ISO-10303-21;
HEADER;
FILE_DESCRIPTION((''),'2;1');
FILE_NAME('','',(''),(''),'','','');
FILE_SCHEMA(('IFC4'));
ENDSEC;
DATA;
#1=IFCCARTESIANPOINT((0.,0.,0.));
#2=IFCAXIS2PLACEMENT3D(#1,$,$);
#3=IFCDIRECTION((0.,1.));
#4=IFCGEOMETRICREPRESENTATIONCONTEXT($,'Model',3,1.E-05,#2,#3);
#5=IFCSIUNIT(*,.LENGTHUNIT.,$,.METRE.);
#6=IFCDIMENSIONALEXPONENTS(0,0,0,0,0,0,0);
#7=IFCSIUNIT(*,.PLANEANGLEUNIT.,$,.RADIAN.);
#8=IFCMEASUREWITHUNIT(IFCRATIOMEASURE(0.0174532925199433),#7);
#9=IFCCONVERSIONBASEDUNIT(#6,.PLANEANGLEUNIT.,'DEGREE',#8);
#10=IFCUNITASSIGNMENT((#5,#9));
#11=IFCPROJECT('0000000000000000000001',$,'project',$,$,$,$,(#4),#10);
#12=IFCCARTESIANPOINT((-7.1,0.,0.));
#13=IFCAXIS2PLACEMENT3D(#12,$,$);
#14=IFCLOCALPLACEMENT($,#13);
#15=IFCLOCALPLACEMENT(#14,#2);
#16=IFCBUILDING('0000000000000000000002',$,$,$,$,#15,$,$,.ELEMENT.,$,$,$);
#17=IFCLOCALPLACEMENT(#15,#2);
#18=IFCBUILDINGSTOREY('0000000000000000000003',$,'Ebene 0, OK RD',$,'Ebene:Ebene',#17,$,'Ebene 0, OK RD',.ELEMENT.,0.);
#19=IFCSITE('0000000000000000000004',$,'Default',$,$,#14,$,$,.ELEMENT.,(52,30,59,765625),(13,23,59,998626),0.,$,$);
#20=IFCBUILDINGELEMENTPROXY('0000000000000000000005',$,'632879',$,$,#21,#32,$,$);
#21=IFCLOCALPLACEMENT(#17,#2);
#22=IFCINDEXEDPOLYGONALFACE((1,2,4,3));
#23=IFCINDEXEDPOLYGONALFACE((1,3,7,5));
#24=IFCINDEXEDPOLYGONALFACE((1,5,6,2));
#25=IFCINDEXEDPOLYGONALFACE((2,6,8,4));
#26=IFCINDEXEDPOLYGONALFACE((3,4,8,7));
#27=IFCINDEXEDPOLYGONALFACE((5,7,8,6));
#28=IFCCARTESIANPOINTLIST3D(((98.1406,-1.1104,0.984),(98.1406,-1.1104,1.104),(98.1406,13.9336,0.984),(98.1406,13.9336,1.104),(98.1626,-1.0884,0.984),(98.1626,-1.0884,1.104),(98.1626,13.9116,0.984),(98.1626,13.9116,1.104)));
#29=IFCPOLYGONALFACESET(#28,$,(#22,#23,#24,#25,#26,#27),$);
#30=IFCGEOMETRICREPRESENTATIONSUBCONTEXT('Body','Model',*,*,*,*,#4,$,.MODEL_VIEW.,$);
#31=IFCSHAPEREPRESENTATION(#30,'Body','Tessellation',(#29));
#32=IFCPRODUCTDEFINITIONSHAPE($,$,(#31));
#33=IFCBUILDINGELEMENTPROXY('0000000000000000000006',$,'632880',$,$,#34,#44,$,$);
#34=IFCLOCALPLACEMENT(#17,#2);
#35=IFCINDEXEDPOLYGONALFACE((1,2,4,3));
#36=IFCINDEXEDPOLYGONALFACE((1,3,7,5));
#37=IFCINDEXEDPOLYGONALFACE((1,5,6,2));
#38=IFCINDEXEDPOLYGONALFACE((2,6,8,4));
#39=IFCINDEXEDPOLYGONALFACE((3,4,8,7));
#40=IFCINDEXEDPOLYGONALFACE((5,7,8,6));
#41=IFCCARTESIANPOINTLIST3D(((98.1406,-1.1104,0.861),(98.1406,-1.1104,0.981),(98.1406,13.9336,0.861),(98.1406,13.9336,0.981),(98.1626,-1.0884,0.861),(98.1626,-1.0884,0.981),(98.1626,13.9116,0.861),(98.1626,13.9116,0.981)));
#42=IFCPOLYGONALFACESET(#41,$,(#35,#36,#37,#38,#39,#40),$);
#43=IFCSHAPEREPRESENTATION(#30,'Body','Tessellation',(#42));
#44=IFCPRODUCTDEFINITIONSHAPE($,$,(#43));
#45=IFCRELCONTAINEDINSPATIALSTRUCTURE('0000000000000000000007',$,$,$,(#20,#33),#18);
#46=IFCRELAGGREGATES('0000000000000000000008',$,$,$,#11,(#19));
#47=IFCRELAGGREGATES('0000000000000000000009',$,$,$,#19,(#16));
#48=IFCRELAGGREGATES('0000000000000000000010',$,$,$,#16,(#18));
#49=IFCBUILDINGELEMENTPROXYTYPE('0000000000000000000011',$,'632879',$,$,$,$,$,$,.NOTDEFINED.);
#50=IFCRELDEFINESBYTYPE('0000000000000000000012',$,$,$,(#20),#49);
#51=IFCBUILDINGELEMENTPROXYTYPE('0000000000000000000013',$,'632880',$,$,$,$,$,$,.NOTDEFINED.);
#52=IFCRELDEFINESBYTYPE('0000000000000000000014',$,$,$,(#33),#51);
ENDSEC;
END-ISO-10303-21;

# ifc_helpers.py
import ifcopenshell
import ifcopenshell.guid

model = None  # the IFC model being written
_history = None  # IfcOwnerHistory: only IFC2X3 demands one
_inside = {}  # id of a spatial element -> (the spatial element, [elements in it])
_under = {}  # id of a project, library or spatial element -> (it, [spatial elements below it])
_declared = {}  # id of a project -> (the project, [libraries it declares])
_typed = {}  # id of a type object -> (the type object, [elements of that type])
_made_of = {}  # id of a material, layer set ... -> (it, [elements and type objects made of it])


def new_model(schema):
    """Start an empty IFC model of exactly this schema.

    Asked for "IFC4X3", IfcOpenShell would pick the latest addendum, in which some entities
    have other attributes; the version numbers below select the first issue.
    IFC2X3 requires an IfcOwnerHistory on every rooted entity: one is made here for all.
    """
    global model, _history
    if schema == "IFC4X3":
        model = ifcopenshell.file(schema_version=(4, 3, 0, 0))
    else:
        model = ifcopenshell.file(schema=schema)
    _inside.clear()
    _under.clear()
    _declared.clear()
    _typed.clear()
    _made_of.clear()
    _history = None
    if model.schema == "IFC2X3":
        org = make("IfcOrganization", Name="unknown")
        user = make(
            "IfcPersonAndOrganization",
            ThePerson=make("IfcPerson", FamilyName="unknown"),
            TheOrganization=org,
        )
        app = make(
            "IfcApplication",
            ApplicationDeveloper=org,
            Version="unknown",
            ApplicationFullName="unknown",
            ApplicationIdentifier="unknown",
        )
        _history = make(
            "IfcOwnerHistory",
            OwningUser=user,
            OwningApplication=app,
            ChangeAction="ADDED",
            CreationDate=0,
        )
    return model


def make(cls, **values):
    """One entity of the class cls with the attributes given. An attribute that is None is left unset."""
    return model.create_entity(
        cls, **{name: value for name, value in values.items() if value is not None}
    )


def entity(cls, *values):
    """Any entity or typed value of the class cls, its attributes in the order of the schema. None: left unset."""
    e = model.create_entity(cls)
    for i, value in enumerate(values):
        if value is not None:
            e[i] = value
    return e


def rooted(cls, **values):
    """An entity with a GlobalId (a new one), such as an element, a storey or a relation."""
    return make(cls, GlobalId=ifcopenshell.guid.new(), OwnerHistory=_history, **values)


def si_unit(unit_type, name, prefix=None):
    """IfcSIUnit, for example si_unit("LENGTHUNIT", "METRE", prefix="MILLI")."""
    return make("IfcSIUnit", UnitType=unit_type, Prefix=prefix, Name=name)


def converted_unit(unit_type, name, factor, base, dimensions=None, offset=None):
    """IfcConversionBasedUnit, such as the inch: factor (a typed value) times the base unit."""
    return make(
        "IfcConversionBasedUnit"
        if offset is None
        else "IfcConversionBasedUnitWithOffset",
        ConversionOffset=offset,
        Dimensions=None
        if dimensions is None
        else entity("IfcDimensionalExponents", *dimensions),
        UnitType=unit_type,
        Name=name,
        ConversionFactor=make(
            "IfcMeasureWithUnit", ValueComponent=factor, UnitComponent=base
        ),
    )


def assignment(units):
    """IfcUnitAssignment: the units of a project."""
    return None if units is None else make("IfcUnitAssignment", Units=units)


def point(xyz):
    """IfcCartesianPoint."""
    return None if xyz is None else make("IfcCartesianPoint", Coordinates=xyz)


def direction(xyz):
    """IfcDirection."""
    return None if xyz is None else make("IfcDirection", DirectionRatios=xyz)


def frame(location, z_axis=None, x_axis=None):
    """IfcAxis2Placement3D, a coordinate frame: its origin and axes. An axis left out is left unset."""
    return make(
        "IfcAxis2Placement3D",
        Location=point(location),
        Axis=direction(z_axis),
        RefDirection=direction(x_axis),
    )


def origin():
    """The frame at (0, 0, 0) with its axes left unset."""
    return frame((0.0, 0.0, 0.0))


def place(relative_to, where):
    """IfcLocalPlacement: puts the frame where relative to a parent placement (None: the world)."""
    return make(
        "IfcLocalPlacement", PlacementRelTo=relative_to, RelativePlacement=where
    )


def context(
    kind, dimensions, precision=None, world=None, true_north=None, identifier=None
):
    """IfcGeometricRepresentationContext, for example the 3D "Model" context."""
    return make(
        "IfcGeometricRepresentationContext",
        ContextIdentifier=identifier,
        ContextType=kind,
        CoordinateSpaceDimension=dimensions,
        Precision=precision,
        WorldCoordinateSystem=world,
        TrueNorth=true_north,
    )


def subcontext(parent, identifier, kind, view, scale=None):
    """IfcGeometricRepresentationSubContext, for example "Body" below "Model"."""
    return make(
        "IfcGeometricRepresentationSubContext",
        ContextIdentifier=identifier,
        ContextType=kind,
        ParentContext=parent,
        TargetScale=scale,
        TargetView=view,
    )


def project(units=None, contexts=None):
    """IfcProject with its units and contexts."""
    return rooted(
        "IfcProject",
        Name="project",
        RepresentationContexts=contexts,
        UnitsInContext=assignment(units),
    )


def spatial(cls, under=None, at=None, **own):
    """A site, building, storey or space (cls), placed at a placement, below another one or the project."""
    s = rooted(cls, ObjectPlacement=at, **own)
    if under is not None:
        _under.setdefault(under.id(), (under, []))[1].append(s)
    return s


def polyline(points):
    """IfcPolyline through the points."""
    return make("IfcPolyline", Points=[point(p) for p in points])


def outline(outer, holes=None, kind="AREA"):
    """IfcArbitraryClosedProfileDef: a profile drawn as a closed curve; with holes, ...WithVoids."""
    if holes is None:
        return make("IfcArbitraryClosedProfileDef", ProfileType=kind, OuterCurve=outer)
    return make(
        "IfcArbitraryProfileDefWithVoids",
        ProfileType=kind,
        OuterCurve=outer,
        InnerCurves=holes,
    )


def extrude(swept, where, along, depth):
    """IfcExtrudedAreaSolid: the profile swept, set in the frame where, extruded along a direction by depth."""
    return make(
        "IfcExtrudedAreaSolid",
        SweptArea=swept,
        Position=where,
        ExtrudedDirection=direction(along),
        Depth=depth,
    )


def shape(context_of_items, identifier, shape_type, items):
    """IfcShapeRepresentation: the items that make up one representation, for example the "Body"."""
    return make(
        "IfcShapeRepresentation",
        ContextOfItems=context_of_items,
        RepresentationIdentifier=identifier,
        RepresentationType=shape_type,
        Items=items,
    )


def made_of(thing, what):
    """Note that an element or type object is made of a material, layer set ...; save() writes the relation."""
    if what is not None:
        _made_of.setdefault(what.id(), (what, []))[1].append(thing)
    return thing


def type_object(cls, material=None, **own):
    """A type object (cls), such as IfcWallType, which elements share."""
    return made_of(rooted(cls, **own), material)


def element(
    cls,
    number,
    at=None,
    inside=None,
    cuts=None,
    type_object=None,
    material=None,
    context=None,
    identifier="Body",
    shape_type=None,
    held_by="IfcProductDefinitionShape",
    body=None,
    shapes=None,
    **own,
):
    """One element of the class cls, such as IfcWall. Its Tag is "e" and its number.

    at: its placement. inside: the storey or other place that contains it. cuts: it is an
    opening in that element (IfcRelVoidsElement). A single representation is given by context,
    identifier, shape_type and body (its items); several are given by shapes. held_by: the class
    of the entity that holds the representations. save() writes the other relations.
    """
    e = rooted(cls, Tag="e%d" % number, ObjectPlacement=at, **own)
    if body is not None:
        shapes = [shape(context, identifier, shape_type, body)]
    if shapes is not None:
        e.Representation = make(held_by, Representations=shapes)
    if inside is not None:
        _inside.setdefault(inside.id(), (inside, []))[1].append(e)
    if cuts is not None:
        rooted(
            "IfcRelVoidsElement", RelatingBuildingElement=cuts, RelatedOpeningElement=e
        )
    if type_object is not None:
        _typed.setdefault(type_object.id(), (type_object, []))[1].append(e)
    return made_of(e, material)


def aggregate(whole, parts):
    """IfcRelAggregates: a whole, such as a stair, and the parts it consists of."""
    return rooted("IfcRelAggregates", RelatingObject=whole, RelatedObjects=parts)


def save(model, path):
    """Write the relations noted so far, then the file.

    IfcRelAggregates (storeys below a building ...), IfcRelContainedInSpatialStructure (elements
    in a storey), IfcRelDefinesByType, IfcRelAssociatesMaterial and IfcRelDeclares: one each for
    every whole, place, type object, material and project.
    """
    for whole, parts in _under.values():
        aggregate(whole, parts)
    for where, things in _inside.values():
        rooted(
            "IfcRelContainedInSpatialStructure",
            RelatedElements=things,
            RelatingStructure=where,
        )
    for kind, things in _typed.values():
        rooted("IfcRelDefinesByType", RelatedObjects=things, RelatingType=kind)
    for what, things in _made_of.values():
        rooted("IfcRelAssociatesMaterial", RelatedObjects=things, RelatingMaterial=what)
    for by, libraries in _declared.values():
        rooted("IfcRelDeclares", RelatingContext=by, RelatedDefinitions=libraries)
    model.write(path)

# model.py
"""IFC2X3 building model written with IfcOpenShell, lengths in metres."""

from ifc_helpers import new_model, entity, si_unit, converted_unit, direction, frame, origin, place, context, subcontext, project, spatial, polyline, outline, extrude, type_object, element, save


model = new_model("IFC2X3")

# Units and contexts
model_context = context("Model", 3, precision=1e-05, world=origin(), true_north=direction((0.0, 1.0)))
body_context = subcontext(model_context, "Body", "Model", "MODEL_VIEW")
ifc_project = project(units=[si_unit("LENGTHUNIT", "METRE"), converted_unit("PLANEANGLEUNIT", "DEGREE", entity("IfcRatioMeasure", 0.0174532925199433), si_unit("PLANEANGLEUNIT", "RADIAN"), dimensions=[0, 0, 0, 0, 0, 0, 0])], contexts=[model_context])

# Site, building, storey
site_placement = place(None, frame((-7.1, 0.0, 0.0)))
site = spatial("IfcSite", under=ifc_project, at=site_placement, Name="Default", CompositionType="ELEMENT", RefLatitude=(52, 30, 59, 765625), RefLongitude=(13, 23, 59, 998626), RefElevation=0.0)
building_placement = place(site_placement, origin())
building = spatial("IfcBuilding", under=site, at=building_placement, CompositionType="ELEMENT")
storey_placement = place(building_placement, origin())
storey = spatial("IfcBuildingStorey", under=building, at=storey_placement, Name="Ebene 0, OK RD", ObjectType="Ebene:Ebene", LongName="Ebene 0, OK RD", CompositionType="ELEMENT", Elevation=0.0)

# Building element proxies
building_element_proxy_type_1 = type_object("IfcBuildingElementProxyType", Name="632879", PredefinedType="NOTDEFINED")
proxy_1_placement = place(storey_placement, origin())
element("IfcBuildingElementProxy", 1, at=proxy_1_placement, inside=storey, type_object=building_element_proxy_type_1, Name="632879", context=body_context, shape_type="SweptSolid", body=[
    extrude(outline(polyline([(-7.5, -0.011), (7.5, -0.011), (7.522, 0.011), (-7.522, 0.011), (-7.5, -0.011)])), frame((98.1516, 6.4116, 0.984), z_axis=(0.0, 0.0, 1.0), x_axis=(0.0, 1.0, 0.0)), (0.0, 0.0, 1.0), 0.12),
])
building_element_proxy_type_2 = type_object("IfcBuildingElementProxyType", Name="632880", PredefinedType="NOTDEFINED")
proxy_2_placement = place(storey_placement, origin())
element("IfcBuildingElementProxy", 2, at=proxy_2_placement, inside=storey, type_object=building_element_proxy_type_2, Name="632880", context=body_context, shape_type="SweptSolid", body=[
    extrude(outline(polyline([(-7.5, -0.011), (7.5, -0.011), (7.522, 0.011), (-7.522, 0.011), (-7.5, -0.011)])), frame((98.1516, 6.4116, 0.861), z_axis=(0.0, 0.0, 1.0), x_axis=(0.0, 1.0, 0.0)), (0.0, 0.0, 1.0), 0.12),
])

save(model, "model.ifc")
